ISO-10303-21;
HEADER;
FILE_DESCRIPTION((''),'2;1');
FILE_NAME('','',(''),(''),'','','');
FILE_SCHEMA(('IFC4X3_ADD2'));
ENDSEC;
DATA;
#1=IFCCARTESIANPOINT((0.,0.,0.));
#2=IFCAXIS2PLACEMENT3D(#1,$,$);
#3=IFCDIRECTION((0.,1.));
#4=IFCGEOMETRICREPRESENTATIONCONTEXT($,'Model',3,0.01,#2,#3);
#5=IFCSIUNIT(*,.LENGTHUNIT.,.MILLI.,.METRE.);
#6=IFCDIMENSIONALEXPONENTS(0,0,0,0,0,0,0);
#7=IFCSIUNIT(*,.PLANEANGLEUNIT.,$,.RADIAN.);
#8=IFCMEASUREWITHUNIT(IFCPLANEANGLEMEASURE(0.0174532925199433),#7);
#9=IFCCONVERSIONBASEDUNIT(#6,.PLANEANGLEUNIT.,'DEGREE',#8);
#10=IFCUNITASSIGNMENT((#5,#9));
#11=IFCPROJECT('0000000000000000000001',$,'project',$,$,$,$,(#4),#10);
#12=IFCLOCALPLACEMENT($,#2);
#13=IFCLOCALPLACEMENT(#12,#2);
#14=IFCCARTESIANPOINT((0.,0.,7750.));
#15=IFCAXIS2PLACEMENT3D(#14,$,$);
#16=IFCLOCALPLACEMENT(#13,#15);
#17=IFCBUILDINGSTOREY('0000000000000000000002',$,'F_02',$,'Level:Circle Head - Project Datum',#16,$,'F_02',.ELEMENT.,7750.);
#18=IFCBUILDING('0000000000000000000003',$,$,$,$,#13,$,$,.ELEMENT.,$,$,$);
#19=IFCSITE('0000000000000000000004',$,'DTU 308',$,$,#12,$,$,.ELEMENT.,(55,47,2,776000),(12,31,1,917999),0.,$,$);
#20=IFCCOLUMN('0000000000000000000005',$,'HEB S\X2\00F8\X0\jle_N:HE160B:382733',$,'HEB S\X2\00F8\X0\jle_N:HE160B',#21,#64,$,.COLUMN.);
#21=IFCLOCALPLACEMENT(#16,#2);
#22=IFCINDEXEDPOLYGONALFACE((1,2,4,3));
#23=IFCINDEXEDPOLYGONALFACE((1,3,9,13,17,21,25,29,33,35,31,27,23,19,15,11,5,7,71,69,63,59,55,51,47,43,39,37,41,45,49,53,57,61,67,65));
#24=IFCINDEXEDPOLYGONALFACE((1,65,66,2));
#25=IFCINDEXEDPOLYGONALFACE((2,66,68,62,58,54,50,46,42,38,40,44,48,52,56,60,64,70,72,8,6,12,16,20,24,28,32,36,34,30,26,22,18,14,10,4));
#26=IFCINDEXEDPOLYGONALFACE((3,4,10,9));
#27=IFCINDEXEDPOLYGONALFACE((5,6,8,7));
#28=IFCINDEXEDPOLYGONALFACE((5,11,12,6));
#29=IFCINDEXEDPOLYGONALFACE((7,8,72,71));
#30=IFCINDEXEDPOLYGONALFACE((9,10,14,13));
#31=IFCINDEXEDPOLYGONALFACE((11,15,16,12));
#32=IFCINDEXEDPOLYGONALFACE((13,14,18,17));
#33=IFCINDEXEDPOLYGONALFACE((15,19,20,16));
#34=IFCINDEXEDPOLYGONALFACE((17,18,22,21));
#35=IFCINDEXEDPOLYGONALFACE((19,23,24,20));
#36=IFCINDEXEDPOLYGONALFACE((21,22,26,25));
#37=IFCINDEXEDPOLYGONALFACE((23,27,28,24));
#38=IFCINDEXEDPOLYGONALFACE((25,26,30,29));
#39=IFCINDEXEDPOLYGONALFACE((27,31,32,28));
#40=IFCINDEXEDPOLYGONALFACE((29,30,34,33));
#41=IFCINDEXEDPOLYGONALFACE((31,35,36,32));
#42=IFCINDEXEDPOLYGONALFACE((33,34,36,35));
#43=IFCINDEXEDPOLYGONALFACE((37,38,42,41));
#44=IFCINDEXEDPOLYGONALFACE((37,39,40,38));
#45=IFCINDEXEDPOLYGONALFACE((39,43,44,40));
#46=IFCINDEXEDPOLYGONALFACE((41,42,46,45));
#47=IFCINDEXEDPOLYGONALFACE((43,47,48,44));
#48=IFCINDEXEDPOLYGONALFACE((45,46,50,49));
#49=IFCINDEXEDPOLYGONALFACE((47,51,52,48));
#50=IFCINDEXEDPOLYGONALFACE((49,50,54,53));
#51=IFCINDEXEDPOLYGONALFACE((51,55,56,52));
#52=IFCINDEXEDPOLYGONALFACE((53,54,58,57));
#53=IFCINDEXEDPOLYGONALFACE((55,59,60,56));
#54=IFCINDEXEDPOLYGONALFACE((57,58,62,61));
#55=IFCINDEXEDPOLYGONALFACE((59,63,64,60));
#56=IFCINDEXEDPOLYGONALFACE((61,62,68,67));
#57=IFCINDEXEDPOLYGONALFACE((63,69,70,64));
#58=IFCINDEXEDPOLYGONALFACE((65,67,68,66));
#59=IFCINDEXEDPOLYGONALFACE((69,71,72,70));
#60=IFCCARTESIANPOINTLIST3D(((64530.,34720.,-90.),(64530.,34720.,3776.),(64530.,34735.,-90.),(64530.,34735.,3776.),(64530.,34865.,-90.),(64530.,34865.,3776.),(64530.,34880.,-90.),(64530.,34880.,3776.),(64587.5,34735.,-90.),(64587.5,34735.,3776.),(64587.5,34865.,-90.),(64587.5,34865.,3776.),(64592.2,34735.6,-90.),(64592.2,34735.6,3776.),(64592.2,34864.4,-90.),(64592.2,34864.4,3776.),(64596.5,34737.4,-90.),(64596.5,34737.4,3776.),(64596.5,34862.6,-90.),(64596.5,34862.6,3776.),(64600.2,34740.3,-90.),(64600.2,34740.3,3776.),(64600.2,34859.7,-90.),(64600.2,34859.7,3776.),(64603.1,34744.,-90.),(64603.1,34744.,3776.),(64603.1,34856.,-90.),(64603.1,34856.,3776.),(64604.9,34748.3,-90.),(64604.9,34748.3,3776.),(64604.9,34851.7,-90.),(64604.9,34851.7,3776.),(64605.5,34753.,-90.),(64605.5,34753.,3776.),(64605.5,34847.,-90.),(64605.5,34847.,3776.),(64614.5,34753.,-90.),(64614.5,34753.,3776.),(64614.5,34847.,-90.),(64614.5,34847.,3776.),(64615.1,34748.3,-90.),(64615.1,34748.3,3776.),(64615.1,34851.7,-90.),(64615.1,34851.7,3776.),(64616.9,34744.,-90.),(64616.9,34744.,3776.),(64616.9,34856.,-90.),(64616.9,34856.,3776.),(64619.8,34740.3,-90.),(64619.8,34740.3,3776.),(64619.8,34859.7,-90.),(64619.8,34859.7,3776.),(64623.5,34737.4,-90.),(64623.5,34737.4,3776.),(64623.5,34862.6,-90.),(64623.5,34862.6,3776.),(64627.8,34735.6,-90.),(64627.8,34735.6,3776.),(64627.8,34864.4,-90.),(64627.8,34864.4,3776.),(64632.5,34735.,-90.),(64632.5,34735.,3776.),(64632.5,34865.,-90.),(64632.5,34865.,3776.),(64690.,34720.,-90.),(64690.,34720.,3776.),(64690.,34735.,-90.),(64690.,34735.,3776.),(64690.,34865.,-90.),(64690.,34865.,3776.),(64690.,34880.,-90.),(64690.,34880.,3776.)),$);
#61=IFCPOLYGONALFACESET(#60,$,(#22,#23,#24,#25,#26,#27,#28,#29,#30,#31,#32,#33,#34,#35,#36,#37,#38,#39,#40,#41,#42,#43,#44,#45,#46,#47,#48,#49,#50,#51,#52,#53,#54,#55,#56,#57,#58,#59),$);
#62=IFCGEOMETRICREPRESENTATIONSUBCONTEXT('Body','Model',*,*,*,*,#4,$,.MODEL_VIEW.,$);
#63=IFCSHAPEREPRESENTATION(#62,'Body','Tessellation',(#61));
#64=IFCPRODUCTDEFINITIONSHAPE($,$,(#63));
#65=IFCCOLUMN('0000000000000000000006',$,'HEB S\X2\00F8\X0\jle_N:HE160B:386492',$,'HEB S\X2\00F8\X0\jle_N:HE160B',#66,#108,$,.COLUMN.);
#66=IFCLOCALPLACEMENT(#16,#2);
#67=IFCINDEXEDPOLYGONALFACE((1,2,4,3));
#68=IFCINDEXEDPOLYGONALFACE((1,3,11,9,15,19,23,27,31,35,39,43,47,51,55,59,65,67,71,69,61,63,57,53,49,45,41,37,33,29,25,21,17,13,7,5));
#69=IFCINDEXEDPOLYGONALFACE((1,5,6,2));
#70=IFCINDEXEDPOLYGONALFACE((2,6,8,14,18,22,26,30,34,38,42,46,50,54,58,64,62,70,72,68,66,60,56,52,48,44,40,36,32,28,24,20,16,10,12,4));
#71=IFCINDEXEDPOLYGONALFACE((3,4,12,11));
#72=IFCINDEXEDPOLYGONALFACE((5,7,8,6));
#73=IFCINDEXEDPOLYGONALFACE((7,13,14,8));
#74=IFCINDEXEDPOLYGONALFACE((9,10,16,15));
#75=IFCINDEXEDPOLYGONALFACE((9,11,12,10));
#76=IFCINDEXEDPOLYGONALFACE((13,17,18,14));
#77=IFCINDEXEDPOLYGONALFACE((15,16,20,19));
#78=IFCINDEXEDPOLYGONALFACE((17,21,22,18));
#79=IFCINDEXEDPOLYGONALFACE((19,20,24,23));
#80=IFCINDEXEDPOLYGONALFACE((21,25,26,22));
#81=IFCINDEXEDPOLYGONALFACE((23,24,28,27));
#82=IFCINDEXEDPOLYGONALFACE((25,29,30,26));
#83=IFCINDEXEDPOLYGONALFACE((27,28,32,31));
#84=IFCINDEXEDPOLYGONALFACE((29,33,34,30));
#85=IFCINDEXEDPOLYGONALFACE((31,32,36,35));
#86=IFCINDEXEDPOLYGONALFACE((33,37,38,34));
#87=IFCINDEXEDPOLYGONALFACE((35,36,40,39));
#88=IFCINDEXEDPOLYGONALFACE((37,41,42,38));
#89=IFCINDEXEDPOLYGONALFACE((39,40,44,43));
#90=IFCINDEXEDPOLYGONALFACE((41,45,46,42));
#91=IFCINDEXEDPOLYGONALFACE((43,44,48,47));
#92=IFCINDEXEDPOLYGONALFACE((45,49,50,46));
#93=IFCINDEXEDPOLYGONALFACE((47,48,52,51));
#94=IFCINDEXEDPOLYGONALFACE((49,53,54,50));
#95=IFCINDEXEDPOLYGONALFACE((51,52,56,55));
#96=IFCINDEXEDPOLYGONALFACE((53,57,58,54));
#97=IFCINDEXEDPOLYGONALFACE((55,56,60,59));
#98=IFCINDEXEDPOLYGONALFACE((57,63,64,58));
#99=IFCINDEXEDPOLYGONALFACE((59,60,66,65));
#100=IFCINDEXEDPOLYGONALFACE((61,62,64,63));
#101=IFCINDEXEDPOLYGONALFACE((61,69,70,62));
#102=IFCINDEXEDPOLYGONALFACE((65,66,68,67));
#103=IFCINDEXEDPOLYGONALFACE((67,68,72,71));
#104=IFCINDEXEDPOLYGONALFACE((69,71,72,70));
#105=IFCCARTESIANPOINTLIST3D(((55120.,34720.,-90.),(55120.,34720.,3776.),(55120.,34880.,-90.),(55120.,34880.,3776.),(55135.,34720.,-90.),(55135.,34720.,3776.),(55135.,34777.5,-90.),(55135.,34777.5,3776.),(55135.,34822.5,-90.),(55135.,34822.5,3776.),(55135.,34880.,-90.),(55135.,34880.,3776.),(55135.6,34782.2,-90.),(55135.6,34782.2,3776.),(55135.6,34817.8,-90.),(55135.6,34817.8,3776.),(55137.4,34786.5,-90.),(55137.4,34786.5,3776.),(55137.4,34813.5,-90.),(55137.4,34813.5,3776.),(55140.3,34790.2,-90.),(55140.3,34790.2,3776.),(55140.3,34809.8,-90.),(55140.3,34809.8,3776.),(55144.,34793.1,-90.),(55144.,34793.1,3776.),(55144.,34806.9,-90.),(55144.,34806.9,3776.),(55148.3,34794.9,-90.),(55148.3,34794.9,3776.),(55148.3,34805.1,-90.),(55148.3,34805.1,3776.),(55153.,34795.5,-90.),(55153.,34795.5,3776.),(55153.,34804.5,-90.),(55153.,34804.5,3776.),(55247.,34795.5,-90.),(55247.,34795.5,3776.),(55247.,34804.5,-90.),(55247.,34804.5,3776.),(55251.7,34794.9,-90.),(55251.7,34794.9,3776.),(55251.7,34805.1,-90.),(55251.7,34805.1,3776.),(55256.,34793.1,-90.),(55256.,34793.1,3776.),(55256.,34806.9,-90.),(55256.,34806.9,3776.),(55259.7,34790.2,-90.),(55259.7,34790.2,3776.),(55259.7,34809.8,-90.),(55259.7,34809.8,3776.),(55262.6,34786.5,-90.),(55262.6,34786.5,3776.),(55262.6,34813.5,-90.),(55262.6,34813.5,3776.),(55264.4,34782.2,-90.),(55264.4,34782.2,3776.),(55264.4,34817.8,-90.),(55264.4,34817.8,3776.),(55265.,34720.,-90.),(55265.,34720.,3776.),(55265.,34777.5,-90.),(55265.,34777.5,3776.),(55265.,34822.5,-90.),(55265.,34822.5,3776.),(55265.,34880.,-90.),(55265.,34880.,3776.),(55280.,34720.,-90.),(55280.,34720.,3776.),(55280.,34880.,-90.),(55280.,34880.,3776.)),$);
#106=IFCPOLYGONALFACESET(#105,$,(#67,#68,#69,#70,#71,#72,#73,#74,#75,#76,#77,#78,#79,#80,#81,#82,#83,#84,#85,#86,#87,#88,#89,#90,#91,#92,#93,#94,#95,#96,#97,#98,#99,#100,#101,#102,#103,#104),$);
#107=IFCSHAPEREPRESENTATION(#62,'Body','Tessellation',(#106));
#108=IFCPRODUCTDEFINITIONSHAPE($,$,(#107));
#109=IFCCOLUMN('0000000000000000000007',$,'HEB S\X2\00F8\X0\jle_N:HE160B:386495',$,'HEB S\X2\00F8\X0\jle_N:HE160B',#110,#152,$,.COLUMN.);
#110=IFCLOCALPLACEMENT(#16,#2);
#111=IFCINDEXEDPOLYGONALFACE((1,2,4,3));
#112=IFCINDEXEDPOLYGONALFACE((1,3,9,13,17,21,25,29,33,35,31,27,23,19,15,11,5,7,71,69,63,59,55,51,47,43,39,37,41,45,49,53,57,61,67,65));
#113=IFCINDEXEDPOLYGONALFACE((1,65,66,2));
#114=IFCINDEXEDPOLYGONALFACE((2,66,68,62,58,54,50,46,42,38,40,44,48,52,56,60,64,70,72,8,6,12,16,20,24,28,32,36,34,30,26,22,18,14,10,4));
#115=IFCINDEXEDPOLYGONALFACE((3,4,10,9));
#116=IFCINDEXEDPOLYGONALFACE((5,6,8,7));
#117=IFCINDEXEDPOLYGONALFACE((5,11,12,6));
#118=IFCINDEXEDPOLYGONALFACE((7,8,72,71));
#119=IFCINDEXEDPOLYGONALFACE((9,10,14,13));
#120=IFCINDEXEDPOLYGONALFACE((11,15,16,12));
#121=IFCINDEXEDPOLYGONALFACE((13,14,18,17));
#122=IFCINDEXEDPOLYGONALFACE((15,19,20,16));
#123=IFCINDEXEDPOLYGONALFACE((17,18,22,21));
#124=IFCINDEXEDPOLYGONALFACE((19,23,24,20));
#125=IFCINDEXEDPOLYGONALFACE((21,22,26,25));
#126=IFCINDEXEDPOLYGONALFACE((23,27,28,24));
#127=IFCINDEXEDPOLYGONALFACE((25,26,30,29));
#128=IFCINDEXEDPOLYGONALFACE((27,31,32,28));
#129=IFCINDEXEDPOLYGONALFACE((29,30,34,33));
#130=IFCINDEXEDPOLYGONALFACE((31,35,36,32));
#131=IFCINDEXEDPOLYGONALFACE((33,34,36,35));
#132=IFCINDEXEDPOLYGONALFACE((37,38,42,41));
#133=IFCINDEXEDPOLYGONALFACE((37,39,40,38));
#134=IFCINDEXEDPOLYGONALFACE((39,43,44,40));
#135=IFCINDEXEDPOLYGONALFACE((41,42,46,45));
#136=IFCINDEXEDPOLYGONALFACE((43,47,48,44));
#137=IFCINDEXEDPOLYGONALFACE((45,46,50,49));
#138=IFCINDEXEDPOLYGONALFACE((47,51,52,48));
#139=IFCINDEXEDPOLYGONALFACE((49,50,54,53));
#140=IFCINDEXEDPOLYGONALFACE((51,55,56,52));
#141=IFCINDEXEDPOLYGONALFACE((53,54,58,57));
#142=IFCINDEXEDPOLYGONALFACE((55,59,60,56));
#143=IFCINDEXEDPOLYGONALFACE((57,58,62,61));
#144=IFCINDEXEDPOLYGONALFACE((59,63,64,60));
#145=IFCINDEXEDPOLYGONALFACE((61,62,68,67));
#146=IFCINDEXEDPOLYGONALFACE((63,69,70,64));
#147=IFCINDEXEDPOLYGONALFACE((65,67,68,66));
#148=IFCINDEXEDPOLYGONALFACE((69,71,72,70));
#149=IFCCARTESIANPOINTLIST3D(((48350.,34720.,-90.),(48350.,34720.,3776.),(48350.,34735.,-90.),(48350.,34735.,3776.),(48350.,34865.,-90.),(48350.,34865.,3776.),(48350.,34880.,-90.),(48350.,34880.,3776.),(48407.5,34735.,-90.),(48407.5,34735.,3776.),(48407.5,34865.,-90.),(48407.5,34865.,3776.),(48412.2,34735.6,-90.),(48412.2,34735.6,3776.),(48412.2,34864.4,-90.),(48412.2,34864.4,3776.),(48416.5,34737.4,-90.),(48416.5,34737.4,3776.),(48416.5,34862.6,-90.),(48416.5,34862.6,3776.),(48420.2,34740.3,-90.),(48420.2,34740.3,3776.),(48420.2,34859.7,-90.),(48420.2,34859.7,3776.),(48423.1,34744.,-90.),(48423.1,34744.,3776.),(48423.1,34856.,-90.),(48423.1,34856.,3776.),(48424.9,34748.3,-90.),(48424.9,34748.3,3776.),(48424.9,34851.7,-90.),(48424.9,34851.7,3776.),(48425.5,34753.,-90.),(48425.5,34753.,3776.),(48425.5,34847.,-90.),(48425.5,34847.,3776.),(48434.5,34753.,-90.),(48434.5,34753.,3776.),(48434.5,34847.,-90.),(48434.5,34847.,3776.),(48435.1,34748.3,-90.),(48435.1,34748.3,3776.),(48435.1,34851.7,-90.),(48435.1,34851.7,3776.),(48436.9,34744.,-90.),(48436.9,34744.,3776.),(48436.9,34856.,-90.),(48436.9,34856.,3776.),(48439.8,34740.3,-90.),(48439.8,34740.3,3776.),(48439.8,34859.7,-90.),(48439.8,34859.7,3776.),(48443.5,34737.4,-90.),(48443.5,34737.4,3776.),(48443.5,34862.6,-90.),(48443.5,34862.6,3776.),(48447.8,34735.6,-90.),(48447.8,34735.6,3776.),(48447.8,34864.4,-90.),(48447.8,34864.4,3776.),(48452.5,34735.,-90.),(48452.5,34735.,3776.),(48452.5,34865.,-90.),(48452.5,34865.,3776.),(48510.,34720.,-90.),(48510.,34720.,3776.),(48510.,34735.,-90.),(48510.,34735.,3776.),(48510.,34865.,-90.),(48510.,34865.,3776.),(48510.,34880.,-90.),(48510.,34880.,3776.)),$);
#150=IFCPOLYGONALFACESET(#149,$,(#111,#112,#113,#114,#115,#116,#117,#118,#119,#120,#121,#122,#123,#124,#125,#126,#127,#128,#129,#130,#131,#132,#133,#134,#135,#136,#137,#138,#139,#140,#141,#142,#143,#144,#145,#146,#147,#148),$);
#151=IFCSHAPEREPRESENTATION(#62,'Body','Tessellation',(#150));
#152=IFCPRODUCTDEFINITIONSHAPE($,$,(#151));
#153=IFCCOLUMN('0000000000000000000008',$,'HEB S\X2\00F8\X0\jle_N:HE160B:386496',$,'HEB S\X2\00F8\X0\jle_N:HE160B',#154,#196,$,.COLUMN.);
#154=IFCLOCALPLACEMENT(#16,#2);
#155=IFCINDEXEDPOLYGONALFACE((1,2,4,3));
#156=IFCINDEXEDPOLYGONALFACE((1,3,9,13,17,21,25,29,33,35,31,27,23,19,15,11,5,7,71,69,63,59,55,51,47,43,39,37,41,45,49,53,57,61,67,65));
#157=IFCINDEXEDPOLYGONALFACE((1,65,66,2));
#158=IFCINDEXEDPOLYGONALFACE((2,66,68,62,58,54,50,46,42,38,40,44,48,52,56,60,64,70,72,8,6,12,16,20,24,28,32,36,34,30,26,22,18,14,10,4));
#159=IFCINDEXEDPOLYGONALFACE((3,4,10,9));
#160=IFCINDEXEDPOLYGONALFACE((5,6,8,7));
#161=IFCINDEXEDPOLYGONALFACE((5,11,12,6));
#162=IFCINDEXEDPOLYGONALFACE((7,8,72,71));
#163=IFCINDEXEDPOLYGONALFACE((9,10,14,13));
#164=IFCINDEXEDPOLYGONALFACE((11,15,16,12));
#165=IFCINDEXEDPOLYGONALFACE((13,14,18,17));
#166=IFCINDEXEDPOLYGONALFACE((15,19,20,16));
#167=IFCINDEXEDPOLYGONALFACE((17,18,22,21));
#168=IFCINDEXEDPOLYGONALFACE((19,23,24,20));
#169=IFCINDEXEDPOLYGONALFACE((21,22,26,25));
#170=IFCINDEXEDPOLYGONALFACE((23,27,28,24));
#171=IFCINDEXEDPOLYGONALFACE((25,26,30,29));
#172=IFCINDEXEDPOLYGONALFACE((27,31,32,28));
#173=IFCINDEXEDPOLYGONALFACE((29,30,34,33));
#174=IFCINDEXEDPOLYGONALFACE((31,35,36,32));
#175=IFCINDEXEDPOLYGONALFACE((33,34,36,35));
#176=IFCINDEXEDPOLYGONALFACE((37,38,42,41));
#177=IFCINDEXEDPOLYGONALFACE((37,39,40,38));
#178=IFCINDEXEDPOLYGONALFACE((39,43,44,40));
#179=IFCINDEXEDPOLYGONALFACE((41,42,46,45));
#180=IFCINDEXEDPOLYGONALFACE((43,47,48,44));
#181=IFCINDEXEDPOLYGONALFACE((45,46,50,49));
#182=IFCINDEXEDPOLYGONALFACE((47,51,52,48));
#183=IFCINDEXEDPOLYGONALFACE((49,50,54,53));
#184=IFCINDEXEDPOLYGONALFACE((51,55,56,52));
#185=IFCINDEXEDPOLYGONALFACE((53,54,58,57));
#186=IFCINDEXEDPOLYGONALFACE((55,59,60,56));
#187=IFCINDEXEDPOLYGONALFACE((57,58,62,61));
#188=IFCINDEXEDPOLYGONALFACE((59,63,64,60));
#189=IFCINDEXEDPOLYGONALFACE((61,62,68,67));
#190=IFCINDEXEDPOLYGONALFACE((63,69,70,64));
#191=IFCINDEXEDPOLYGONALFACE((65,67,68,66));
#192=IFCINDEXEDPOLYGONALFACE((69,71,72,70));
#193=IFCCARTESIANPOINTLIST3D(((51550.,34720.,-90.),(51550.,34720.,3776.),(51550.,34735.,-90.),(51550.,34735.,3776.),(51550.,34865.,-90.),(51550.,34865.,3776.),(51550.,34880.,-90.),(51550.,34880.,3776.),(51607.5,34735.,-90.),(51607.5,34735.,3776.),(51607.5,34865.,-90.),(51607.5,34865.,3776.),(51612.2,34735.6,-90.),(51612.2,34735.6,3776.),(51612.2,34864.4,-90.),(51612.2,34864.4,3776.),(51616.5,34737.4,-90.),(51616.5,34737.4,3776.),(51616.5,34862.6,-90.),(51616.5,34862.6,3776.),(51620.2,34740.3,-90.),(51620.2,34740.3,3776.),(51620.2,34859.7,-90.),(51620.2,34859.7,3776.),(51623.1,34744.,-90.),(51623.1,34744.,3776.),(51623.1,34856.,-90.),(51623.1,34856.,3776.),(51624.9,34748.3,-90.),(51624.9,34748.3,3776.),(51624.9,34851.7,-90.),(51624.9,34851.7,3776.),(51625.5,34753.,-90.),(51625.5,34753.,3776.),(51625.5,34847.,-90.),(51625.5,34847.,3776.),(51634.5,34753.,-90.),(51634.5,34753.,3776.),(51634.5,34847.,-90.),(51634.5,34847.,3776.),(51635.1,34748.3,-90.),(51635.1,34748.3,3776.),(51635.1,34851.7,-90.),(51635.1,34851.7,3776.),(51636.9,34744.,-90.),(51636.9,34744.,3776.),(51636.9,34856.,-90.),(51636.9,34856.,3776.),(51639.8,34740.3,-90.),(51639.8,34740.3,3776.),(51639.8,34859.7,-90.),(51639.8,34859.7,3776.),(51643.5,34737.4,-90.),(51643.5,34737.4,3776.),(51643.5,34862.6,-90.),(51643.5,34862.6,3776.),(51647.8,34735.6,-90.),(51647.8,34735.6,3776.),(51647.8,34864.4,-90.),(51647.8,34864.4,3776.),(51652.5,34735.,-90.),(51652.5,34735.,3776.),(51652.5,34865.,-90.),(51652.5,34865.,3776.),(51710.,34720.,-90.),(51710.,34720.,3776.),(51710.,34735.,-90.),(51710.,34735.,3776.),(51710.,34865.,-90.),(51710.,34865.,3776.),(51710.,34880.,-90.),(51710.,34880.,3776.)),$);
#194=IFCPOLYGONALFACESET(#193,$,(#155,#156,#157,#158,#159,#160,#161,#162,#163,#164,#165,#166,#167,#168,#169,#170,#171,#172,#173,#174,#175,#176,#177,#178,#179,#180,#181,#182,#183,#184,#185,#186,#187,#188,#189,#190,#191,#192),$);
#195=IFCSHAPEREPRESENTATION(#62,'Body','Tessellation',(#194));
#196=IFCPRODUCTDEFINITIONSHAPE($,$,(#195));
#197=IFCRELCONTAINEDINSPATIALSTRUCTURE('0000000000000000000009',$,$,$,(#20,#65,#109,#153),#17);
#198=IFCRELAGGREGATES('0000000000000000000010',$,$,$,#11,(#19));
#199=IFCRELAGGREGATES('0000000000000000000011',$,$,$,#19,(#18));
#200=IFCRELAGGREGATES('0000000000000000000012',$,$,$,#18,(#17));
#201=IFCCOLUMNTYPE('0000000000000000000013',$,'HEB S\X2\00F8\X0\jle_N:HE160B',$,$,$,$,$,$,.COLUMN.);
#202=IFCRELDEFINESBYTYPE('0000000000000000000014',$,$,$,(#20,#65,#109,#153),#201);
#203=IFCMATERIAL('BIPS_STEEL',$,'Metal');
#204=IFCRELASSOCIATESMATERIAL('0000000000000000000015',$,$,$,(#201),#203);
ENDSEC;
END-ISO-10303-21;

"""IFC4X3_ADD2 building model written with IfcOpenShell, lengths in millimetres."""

from ifc_helpers import new_model, entity, si_unit, converted_unit, direction, frame, frame_2d, origin, place, context, subcontext, project, spatial, i_section, extrude, source, transform, mapped, material, material_profile, profile_set, type_object, element, save


model = new_model("IFC4X3_ADD2")

# Units and contexts
model_context = context("Model", 3, precision=0.01, world=origin(), true_north=direction((0.0, 1.0)))
body_context = subcontext(model_context, "Body", "Model", "MODEL_VIEW")
ifc_project = project(units=[si_unit("LENGTHUNIT", "METRE", prefix="MILLI"), converted_unit("PLANEANGLEUNIT", "DEGREE", entity("IfcPlaneAngleMeasure", 0.0174532925199433), si_unit("PLANEANGLEUNIT", "RADIAN"), dimensions=[0, 0, 0, 0, 0, 0, 0])], contexts=[model_context])

# Site, building, storey
site_placement = place(None, origin())
site = spatial("IfcSite", under=ifc_project, at=site_placement, Name="DTU 308", CompositionType="ELEMENT", RefLatitude=(55, 47, 2, 776000), RefLongitude=(12, 31, 1, 917999), RefElevation=0.0)
building_placement = place(site_placement, origin())
building = spatial("IfcBuilding", under=site, at=building_placement, CompositionType="ELEMENT")
storey_placement = place(building_placement, frame((0.0, 0.0, 7750.0)))
storey = spatial("IfcBuildingStorey", under=building, at=storey_placement, Name="F_02", ObjectType="Level:Circle Head - Project Datum", LongName="F_02", CompositionType="ELEMENT", Elevation=7750.0)

# Columns
ifc_material = material(Name="BIPS_STEEL", Category="Metal")
ifc_material_profile_1 = material_profile(ifc_material, i_section(OverallWidth=160.0, OverallDepth=160.0, WebThickness=9.0, FlangeThickness=15.0, FilletRadius=18.0, at=frame_2d((0.0, 0.0), x_axis=(1.0, 0.0))), Name="HE160B")
ifc_profile_set_1 = profile_set([ifc_material_profile_1], Name="HE160B")
column_type_1 = type_object("IfcColumnType", Name="HEB Søjle_N:HE160B", PredefinedType="COLUMN", material=ifc_profile_set_1)
shared_shape_1 = source(origin(), body_context, "Body", "SweptSolid", [
    extrude(i_section(OverallWidth=160.0, OverallDepth=160.0, WebThickness=9.0, FlangeThickness=15.0, FilletRadius=18.0, at=frame_2d((0.0, 0.0), x_axis=(1.0, 0.0))), frame((0.0, 0.0, 7660.0), z_axis=(0.0, 0.0, 1.0), x_axis=(-1.0, 0.0, 0.0)), (0.0, 0.0, 1.0), 3866.0),
])
for number, where, name in (
    (1, (64610.0, 34800.0, -7750.0), "HEB Søjle_N:HE160B:382733"),
):
    element("IfcColumn", number, at=place(storey_placement, frame(where)), inside=storey, type_object=column_type_1, Name=name, ObjectType="HEB Søjle_N:HE160B", PredefinedType="COLUMN", context=body_context, shape_type="MappedRepresentation", body=[
        mapped(shared_shape_1, transform((0.0, 0.0, 0.0), scale=1.0)),
    ])
column_1_placement = place(storey_placement, frame((55200.0, 34800.0, -7750.0), z_axis=(0.0, 0.0, 1.0), x_axis=(0.0, 1.0, 0.0)))
element("IfcColumn", 2, at=column_1_placement, inside=storey, type_object=column_type_1, Name="HEB Søjle_N:HE160B:386492", ObjectType="HEB Søjle_N:HE160B", PredefinedType="COLUMN", context=body_context, shape_type="MappedRepresentation", body=[
    mapped(shared_shape_1, transform((0.0, 0.0, 0.0), scale=1.0)),
])
for number, where, name in (
    (3, (48430.0, 34800.0, -7750.0), "HEB Søjle_N:HE160B:386495"),
    (4, (51630.0, 34800.0, -7750.0), "HEB Søjle_N:HE160B:386496"),
):
    element("IfcColumn", number, at=place(storey_placement, frame(where)), inside=storey, type_object=column_type_1, Name=name, ObjectType="HEB Søjle_N:HE160B", PredefinedType="COLUMN", context=body_context, shape_type="MappedRepresentation", body=[
        mapped(shared_shape_1, transform((0.0, 0.0, 0.0), scale=1.0)),
    ])

save(model, "model.ifc")
